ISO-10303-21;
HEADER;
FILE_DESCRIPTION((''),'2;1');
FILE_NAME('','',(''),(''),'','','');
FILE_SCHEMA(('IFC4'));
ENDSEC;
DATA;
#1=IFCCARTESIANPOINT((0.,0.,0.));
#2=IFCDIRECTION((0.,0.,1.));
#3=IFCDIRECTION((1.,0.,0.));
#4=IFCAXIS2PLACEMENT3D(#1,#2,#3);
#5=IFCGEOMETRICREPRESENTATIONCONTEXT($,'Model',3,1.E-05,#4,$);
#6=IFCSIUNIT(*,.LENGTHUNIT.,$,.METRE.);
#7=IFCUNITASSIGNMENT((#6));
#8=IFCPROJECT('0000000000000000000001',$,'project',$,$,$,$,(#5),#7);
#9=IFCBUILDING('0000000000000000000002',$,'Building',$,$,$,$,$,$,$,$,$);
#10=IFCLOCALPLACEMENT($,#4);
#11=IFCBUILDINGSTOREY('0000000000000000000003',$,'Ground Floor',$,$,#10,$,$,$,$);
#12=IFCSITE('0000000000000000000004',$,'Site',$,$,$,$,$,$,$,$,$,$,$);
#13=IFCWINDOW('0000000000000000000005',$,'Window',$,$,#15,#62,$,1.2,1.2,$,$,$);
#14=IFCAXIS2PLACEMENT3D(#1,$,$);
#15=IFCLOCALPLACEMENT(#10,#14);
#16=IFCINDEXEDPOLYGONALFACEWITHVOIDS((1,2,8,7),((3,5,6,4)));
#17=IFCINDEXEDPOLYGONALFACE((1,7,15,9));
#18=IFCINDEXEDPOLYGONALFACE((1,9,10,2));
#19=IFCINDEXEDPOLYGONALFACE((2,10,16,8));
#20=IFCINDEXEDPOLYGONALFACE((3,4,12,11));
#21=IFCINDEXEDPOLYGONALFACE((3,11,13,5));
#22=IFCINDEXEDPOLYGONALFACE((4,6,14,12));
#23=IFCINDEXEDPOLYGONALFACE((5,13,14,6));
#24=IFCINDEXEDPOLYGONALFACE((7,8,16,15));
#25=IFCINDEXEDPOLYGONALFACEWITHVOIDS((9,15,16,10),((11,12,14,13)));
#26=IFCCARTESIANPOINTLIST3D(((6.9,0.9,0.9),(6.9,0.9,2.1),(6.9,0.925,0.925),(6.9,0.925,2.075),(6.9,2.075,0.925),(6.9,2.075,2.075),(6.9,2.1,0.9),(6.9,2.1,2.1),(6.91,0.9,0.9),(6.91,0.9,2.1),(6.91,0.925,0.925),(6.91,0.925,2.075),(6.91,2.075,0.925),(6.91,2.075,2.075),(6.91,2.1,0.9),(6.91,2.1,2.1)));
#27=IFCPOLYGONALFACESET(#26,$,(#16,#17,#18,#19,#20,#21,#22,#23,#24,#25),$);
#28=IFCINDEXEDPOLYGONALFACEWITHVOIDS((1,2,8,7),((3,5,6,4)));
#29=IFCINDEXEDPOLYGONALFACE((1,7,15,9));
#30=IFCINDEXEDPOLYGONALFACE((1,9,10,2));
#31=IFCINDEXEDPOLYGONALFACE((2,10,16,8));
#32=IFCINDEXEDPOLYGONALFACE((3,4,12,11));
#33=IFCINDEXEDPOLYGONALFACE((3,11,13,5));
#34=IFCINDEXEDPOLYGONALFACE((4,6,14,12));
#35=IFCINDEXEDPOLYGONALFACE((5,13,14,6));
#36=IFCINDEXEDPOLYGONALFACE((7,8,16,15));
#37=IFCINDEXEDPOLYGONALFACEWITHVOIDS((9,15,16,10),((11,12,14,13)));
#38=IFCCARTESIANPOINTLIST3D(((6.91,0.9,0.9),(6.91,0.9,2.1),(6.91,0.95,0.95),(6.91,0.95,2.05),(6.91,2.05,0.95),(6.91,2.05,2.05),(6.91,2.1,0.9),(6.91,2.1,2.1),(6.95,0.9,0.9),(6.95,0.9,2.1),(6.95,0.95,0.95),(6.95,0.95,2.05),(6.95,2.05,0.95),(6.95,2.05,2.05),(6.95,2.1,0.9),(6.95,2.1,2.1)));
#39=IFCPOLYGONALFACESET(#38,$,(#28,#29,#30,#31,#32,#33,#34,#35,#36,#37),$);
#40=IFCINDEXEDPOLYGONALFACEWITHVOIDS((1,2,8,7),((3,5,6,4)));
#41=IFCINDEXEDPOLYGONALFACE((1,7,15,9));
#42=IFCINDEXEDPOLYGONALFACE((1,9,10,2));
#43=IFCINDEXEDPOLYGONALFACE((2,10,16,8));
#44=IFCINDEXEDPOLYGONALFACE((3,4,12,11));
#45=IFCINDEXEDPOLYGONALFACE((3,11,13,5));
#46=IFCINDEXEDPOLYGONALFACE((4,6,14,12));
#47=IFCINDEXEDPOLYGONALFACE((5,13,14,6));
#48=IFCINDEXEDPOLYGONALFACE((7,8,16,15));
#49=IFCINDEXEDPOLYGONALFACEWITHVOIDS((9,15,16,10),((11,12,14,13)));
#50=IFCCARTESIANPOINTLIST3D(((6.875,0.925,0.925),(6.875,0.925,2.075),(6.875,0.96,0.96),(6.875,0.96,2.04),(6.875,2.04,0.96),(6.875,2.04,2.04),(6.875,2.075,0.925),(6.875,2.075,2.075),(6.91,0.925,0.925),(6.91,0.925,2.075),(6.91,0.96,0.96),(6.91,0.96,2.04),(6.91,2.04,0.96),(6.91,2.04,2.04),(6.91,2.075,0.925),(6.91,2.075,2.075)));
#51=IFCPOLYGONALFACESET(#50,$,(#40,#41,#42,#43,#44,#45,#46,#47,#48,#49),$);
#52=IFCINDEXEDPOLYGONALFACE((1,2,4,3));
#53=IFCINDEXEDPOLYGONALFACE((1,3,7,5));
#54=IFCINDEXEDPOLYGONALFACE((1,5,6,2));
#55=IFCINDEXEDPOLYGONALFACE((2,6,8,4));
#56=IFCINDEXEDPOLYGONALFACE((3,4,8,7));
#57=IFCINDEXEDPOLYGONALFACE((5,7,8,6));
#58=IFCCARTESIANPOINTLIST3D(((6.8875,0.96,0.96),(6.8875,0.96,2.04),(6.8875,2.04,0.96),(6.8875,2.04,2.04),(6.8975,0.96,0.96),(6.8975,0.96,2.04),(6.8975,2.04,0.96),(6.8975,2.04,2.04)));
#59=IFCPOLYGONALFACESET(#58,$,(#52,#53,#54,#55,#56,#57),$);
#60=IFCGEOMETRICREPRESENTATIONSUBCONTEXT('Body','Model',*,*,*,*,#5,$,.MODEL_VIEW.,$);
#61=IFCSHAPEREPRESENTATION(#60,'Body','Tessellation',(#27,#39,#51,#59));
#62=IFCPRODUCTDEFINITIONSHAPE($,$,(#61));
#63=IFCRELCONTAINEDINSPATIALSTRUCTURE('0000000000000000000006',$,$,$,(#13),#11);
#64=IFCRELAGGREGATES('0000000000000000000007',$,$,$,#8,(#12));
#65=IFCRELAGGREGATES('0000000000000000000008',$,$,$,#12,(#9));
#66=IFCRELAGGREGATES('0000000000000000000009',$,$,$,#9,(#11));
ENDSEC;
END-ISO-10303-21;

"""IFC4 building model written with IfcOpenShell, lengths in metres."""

from ifc_helpers import new_model, si_unit, frame, origin_with_axes, place, context, subcontext, project, spatial, line, indexed_curve, outline, extrude, element, save


model = new_model("IFC4")

# Units and contexts
model_context = context("Model", 3, precision=1e-05, world=origin_with_axes())
body_context = subcontext(model_context, "Body", "Model", "MODEL_VIEW")
ifc_project = project(units=[si_unit("LENGTHUNIT", "METRE")], contexts=[model_context])

# Site, building, storey
site = spatial("IfcSite", under=ifc_project, Name="Site")
building = spatial("IfcBuilding", under=site, Name="Building")
storey_placement = place(None, origin_with_axes())
storey = spatial("IfcBuildingStorey", under=building, at=storey_placement, Name="Ground Floor")

# Window
window_1_placement = place(storey_placement, frame((7.0, 0.9, 0.9), z_axis=(0.0, 0.0, 1.0), x_axis=(0.0, 1.0, 0.0)))
element("IfcWindow", 1, at=window_1_placement, inside=storey, Name="Window", OverallHeight=1.2, OverallWidth=1.2, context=body_context, shape_type="SweptSolid", body=[
    extrude(outline(indexed_curve([(0.0, 0.0), (1.2, 0.0), (1.2, 1.2), (0.0, 1.2)], segments=[line(1, 2, 3, 4, 1)]), holes=[indexed_curve([(0.025, 0.025), (1.175, 0.025), (1.175, 1.175), (0.025, 1.175)], segments=[line(1, 2, 3, 4, 1)])]), frame((0.0, 0.09, 0.0), z_axis=(0.0, -1.0, 0.0), x_axis=(1.0, 0.0, 0.0)), (0.0, 0.0, -1.0), 0.01),
    extrude(outline(indexed_curve([(0.0, 0.0), (1.2, 0.0), (1.2, 1.2), (0.0, 1.2)], segments=[line(1, 2, 3, 4, 1)]), holes=[indexed_curve([(0.05, 0.05), (1.15, 0.05), (1.15, 1.15), (0.05, 1.15)], segments=[line(1, 2, 3, 4, 1)])]), frame((0.0, 0.05, 0.0), z_axis=(0.0, -1.0, 0.0), x_axis=(1.0, 0.0, 0.0)), (0.0, 0.0, -1.0), 0.04),
    extrude(outline(indexed_curve([(0.0, 0.0), (1.15, 0.0), (1.15, 1.15), (0.0, 1.15)], segments=[line(1, 2, 3, 4, 1)]), holes=[indexed_curve([(0.035, 0.035), (1.115, 0.035), (1.115, 1.115), (0.035, 1.115)], segments=[line(1, 2, 3, 4, 1)])]), frame((0.025, 0.09, 0.025), z_axis=(0.0, -1.0, 0.0), x_axis=(1.0, 0.0, 0.0)), (0.0, 0.0, -1.0), 0.035),
    extrude(outline(indexed_curve([(0.035, 0.035), (1.115, 0.035), (1.115, 1.115), (0.035, 1.115)], segments=[line(1, 2, 3, 4, 1)])), frame((0.025, 0.1025, 0.025), z_axis=(0.0, -1.0, 0.0), x_axis=(1.0, 0.0, 0.0)), (0.0, 0.0, -1.0), 0.01),
])

save(model, "model.ifc")
